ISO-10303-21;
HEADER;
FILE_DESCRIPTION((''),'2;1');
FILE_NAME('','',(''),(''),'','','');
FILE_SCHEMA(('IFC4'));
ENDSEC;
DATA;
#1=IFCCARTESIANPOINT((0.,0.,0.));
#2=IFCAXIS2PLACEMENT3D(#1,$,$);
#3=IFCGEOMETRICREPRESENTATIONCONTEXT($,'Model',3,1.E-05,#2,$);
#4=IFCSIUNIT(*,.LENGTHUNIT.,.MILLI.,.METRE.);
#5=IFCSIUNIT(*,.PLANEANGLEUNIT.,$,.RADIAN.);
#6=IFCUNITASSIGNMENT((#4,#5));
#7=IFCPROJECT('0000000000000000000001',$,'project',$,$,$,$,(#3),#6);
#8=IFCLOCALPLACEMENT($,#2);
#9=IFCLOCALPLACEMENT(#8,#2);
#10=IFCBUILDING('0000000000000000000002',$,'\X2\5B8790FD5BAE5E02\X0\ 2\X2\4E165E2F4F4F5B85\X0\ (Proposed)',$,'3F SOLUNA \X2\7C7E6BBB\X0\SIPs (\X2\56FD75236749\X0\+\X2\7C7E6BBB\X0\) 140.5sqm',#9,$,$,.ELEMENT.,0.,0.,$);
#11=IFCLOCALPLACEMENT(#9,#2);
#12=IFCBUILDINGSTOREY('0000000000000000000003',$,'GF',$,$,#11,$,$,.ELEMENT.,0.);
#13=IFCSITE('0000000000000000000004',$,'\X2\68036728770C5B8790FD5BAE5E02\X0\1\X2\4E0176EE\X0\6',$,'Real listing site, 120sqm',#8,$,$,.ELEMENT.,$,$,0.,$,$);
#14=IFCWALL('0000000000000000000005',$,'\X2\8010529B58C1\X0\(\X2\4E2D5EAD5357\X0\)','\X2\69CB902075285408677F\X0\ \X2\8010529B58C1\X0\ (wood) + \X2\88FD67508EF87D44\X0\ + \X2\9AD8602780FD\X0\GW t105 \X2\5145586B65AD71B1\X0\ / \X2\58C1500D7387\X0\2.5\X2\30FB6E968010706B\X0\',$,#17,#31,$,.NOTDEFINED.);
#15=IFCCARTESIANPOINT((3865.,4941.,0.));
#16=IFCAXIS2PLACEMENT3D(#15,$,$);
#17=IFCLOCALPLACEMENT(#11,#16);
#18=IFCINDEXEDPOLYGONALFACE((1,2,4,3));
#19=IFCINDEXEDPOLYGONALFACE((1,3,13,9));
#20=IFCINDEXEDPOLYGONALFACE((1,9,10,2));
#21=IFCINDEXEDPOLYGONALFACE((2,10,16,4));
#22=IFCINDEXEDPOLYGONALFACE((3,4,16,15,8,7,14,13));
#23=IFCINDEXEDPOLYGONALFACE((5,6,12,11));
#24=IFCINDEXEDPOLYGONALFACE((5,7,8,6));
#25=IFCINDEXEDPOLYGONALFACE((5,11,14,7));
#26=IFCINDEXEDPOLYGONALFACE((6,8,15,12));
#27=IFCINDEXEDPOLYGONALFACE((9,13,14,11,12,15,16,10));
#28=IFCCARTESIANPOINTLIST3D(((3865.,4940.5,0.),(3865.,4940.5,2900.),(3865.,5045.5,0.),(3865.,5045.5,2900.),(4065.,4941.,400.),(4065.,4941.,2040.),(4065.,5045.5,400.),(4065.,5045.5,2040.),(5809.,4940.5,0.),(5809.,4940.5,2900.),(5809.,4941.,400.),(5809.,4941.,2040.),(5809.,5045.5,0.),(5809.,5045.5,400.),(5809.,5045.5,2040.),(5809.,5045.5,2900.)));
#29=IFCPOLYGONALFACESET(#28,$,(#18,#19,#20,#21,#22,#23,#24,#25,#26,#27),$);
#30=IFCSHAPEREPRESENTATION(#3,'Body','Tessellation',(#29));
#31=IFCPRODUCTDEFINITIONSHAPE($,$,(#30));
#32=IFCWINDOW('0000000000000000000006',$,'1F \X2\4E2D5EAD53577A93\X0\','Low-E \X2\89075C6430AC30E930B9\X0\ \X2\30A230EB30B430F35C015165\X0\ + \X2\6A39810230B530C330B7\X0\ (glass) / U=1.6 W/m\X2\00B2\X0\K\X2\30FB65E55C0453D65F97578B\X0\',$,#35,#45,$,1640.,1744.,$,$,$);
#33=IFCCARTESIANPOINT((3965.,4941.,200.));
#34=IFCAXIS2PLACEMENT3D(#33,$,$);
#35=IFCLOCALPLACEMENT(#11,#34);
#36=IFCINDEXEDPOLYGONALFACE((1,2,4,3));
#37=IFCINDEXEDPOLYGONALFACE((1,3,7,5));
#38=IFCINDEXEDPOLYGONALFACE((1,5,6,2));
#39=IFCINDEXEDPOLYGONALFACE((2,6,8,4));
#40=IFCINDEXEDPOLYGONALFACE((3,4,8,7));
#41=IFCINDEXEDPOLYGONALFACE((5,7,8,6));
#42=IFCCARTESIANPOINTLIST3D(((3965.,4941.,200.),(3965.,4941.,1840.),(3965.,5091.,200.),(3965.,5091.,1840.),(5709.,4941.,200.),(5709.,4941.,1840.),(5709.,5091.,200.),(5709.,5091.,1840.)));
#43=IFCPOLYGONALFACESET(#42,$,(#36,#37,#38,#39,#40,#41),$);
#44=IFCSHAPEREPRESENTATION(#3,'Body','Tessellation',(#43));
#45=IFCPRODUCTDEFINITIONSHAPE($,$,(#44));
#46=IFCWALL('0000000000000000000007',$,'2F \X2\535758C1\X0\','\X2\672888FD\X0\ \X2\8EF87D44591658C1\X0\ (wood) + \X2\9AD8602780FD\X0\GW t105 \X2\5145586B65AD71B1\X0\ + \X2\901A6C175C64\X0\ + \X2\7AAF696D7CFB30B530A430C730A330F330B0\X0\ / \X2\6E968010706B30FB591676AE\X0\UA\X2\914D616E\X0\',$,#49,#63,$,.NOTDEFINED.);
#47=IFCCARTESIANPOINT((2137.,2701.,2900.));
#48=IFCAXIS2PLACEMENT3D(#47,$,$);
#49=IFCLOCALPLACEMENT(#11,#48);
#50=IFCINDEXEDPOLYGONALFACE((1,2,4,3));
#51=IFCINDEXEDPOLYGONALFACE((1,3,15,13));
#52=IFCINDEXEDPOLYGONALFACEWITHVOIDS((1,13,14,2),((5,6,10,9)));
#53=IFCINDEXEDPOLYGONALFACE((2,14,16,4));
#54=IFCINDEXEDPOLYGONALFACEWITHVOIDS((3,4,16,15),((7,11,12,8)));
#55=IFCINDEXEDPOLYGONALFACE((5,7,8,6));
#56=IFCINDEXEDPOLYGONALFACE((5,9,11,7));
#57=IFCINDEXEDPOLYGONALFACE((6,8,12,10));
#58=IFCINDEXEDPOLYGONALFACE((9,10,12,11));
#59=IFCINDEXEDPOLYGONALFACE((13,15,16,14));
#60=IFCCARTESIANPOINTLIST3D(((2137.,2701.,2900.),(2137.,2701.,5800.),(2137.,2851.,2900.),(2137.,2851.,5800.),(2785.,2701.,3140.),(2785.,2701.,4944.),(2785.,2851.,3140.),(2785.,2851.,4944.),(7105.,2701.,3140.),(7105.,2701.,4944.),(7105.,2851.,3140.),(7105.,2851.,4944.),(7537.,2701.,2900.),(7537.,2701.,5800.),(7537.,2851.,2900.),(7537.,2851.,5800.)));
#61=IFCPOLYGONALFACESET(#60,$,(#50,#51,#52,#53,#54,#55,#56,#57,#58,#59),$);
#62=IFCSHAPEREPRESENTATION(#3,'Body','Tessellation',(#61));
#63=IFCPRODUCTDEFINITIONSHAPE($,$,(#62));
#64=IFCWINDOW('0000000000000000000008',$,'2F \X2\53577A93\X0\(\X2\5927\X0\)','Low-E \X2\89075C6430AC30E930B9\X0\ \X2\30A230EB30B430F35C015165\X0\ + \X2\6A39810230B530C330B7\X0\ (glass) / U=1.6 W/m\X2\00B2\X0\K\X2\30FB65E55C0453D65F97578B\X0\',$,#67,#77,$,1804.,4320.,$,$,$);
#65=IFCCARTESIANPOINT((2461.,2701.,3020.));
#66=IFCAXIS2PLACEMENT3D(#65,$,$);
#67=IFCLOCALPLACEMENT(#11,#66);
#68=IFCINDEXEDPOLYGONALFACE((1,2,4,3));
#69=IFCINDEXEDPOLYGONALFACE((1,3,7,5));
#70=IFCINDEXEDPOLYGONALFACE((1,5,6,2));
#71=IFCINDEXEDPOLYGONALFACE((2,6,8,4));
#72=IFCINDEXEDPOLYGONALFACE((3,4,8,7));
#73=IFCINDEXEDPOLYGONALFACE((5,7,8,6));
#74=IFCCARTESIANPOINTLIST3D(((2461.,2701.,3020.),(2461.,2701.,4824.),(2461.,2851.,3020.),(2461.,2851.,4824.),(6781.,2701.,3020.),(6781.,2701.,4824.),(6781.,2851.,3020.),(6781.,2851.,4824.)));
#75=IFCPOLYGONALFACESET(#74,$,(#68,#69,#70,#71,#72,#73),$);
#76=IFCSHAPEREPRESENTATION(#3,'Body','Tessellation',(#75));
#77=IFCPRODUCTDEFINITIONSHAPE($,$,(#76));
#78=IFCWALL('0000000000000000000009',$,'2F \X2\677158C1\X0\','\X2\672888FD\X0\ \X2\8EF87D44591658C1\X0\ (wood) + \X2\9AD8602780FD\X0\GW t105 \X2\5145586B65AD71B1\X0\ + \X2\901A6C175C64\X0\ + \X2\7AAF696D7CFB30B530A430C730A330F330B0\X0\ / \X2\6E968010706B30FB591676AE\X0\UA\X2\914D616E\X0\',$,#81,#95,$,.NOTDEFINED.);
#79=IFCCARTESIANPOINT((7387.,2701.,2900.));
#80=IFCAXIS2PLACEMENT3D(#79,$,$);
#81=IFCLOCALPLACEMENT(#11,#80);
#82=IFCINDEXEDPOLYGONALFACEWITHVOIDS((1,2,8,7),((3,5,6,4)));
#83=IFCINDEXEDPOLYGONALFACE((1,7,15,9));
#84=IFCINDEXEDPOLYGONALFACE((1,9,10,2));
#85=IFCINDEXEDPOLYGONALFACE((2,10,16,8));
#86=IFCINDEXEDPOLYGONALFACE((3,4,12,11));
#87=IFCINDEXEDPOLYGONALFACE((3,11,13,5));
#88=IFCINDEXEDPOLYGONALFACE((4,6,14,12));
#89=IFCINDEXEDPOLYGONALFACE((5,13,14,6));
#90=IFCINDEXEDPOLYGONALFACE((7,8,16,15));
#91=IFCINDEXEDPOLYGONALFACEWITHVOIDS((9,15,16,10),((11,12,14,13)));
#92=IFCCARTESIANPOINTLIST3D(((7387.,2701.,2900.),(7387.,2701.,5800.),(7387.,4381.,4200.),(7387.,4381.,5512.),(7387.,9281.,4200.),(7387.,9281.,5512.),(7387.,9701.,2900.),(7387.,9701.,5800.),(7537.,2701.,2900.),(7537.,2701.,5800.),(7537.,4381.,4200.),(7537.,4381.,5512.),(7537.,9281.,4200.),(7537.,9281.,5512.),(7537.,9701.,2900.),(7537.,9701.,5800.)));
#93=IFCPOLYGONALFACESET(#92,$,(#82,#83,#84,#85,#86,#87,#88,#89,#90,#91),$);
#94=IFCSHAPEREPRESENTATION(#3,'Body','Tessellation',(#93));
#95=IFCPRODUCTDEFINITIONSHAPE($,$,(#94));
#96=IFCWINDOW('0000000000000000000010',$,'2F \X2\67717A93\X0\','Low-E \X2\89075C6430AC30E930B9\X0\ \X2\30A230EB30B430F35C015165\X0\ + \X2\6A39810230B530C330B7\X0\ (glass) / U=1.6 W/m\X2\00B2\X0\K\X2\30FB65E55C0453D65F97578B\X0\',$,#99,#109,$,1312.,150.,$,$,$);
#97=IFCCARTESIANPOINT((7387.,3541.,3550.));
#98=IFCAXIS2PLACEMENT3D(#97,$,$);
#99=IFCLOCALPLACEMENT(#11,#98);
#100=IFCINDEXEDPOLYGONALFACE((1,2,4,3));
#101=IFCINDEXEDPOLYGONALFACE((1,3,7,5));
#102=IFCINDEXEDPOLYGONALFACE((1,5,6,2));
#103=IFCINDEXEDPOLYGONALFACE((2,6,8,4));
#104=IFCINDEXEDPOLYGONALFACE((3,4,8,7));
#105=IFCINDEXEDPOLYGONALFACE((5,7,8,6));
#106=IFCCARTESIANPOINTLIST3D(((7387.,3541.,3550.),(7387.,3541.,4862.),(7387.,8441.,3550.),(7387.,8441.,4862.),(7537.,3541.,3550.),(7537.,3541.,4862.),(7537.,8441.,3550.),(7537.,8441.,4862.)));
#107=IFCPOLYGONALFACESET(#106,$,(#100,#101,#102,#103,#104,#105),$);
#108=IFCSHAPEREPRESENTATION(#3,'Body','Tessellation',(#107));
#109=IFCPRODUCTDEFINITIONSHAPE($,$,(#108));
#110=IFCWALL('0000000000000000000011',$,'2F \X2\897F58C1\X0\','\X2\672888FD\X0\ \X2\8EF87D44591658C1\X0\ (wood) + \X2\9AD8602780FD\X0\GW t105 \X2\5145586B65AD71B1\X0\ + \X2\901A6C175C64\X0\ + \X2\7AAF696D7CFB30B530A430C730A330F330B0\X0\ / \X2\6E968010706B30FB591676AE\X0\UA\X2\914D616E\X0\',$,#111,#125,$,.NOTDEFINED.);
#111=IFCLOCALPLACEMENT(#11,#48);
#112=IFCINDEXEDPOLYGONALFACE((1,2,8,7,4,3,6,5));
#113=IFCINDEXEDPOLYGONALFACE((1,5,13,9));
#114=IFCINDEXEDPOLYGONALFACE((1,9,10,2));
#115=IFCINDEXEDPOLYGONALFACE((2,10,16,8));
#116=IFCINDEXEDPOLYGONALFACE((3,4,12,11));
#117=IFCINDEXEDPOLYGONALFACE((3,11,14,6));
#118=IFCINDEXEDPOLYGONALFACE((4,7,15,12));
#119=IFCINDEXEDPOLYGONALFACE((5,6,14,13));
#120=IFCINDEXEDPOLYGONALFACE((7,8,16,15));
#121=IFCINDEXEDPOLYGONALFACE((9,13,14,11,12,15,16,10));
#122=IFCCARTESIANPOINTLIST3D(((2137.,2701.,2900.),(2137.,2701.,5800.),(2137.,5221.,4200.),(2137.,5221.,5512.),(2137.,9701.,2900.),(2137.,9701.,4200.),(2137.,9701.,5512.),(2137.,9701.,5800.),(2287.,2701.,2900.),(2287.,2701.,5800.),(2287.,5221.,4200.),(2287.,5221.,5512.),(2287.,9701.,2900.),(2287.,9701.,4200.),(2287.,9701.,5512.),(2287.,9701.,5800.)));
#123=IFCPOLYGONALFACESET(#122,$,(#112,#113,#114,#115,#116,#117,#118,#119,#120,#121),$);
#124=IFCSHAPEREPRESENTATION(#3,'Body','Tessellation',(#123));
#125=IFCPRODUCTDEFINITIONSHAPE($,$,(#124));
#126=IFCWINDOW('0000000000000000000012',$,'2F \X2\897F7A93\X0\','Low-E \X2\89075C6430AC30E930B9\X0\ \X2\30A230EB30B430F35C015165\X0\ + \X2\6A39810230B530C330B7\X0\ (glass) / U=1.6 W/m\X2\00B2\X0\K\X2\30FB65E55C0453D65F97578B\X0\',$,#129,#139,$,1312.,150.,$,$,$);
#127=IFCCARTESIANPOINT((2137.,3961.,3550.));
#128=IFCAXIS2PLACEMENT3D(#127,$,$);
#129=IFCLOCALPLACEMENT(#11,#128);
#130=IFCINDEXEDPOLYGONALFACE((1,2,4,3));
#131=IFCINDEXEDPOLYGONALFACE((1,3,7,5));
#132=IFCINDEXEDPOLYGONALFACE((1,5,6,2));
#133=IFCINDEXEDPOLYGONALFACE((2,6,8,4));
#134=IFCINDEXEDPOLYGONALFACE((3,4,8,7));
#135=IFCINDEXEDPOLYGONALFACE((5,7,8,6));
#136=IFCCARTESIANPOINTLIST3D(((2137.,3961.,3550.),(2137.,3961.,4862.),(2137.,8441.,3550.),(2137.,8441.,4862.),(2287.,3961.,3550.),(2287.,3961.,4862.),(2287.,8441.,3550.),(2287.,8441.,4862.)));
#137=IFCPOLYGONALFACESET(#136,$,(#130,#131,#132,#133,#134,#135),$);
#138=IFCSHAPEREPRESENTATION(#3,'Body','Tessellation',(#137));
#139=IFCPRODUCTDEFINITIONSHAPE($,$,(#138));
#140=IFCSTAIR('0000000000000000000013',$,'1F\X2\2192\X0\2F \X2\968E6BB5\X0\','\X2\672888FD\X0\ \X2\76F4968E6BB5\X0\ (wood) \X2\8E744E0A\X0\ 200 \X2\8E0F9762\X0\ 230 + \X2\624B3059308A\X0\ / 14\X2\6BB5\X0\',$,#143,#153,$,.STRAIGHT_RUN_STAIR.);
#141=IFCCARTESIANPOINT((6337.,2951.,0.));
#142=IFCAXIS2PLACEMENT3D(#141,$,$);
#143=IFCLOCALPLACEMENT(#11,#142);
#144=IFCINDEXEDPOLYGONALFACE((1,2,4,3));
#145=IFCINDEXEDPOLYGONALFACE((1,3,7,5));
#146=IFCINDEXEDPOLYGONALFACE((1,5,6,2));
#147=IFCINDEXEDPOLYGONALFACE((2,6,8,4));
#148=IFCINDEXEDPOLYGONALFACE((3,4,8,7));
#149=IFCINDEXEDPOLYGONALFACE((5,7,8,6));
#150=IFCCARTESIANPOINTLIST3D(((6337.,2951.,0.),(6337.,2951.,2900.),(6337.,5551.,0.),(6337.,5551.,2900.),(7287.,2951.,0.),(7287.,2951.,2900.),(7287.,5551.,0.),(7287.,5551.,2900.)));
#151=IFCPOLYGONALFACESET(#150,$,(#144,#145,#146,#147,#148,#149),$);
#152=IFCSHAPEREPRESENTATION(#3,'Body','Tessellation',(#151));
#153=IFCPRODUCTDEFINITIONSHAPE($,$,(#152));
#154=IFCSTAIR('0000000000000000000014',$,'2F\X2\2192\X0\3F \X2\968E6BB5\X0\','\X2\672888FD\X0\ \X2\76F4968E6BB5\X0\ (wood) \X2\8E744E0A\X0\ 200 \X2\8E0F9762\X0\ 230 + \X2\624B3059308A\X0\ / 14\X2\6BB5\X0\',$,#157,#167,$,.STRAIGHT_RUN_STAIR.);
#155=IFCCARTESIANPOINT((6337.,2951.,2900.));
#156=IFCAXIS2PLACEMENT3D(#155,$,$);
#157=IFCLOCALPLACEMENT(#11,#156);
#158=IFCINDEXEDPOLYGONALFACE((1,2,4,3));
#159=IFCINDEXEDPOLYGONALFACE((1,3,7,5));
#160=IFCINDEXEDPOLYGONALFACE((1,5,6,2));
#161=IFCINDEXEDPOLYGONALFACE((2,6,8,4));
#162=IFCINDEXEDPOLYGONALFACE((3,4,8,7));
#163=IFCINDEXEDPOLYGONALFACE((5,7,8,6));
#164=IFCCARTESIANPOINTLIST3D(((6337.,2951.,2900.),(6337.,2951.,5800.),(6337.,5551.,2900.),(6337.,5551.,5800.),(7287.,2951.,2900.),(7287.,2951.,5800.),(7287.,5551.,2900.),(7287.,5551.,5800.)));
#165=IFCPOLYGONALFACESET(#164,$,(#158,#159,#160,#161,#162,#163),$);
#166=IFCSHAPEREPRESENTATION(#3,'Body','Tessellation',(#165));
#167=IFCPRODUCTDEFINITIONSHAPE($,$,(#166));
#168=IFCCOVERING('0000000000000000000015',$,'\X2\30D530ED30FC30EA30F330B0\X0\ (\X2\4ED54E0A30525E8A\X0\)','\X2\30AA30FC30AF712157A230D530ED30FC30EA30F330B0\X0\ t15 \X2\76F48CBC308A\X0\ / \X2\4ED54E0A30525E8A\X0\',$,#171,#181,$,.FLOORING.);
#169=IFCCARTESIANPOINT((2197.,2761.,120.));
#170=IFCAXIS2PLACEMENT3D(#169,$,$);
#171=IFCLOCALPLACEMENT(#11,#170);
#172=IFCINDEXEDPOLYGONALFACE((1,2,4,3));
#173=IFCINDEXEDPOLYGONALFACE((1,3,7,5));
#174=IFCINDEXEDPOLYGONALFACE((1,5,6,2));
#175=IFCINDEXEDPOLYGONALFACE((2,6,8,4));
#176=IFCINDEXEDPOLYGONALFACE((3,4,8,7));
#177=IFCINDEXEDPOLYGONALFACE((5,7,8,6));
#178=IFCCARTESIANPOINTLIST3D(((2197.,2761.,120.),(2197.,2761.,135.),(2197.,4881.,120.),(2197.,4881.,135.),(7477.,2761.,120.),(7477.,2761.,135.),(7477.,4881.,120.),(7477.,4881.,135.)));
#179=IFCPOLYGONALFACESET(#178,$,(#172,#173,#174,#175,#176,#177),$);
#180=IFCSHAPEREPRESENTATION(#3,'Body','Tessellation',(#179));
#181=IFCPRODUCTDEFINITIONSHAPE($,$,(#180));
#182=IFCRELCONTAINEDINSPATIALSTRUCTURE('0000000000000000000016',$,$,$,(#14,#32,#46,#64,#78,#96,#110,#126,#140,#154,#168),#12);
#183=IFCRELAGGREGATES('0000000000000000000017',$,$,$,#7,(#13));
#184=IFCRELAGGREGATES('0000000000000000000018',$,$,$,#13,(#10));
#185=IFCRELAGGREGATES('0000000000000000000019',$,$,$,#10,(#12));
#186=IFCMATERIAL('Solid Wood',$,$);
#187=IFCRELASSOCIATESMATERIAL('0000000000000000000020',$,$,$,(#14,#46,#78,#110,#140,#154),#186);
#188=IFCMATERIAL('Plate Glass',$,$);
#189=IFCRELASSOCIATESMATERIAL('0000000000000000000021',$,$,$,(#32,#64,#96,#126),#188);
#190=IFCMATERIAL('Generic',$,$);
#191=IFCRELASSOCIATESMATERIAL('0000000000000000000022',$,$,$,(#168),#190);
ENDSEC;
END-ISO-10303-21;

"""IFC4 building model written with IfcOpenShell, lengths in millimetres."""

from ifc_helpers import new_model, si_unit, frame, frame_2d, origin, place, context, project, spatial, rectangle, extrude, material, element, fill, save


model = new_model("IFC4")

# Units and contexts
model_context = context("Model", 3, precision=1e-05, world=origin())
ifc_project = project(units=[si_unit("LENGTHUNIT", "METRE", prefix="MILLI"), si_unit("PLANEANGLEUNIT", "RADIAN")], contexts=[model_context])

# Site, building, storey
site_placement = place(None, origin())
site = spatial("IfcSite", under=ifc_project, at=site_placement, Name="栃木県宇都宮市1丁目6", ObjectType="Real listing site, 120sqm", CompositionType="ELEMENT", RefElevation=0.0)
building_placement = place(site_placement, origin())
building = spatial("IfcBuilding", under=site, at=building_placement, Name="宇都宮市 2世帯住宅 (Proposed)", ObjectType="3F SOLUNA 籾殻SIPs (国産杉+籾殻) 140.5sqm", CompositionType="ELEMENT", ElevationOfRefHeight=0.0, ElevationOfTerrain=0.0)
storey_placement = place(building_placement, origin())
storey = spatial("IfcBuildingStorey", under=building, at=storey_placement, Name="GF", CompositionType="ELEMENT", Elevation=0.0)

# Shared definitions
ifc_material_1 = material(Name="Solid Wood")

# Shared definitions
ifc_material_2 = material(Name="Plate Glass")

# Walls, openings, windows
wall_1_placement = place(storey_placement, frame((3865.0, 4941.0, 0.0)))
wall_1 = element("IfcWall", 1, at=wall_1_placement, inside=storey, material=ifc_material_1, Name="耐力壁(中庭南)", Description="構造用合板 耐力壁 (wood) + 製材軸組 + 高性能GW t105 充填断熱 / 壁倍率2.5・準耐火", PredefinedType="NOTDEFINED", context=model_context, shape_type="SweptSolid", body=[
    extrude(rectangle(XDim=1944.0, YDim=105.0, at=frame_2d((972.0, 52.0))), frame((3865.0, 4941.0, 0.0)), (0.0, 0.0, 1.0), 2900.0),
])
opening_1_placement = place(storey_placement, frame((3965.0, 4941.0, 200.0)))
opening_1 = element("IfcOpeningElement", 2, at=opening_1_placement, cuts=wall_1, PredefinedType="NOTDEFINED", context=model_context, shape_type="SweptSolid", body=[
    extrude(rectangle(XDim=1744.0, YDim=150.0, at=frame_2d((872.0, 75.0))), frame((3965.0, 4941.0, 200.0)), (0.0, 0.0, 1.0), 1640.0),
])
window_1_placement = place(storey_placement, frame((3965.0, 4941.0, 200.0)))
window_1 = element("IfcWindow", 3, at=window_1_placement, inside=storey, material=ifc_material_2, Name="1F 中庭南窓", Description="Low-E 複層ガラス アルゴン封入 + 樹脂サッシ (glass) / U=1.6 W/m²K・日射取得型", OverallHeight=1640.0, OverallWidth=1744.0, context=model_context, shape_type="SweptSolid", body=[
    extrude(rectangle(XDim=1744.0, YDim=150.0, at=frame_2d((872.0, 75.0))), frame((3965.0, 4941.0, 200.0)), (0.0, 0.0, 1.0), 1640.0),
])
fill(opening_1, window_1)
wall_2_placement = place(storey_placement, frame((2137.0, 2701.0, 2900.0)))
wall_2 = element("IfcWall", 4, at=wall_2_placement, inside=storey, material=ifc_material_1, Name="2F 南壁", Description="木製 軸組外壁 (wood) + 高性能GW t105 充填断熱 + 通気層 + 窯業系サイディング / 準耐火・外皮UA配慮", PredefinedType="NOTDEFINED", context=model_context, shape_type="SweptSolid", body=[
    extrude(rectangle(XDim=5400.0, YDim=150.0, at=frame_2d((2700.0, 75.0))), frame((2137.0, 2701.0, 2900.0)), (0.0, 0.0, 1.0), 2900.0),
])
opening_2_placement = place(storey_placement, frame((2461.0, 2701.0, 3020.0)))
opening_2 = element("IfcOpeningElement", 5, at=opening_2_placement, cuts=wall_2, PredefinedType="NOTDEFINED", context=model_context, shape_type="SweptSolid", body=[
    extrude(rectangle(XDim=4320.0, YDim=150.0, at=frame_2d((2160.0, 75.0))), frame((2461.0, 2701.0, 3020.0)), (0.0, 0.0, 1.0), 1804.0),
])
window_2_placement = place(storey_placement, frame((2461.0, 2701.0, 3020.0)))
window_2 = element("IfcWindow", 6, at=window_2_placement, inside=storey, material=ifc_material_2, Name="2F 南窓(大)", Description="Low-E 複層ガラス アルゴン封入 + 樹脂サッシ (glass) / U=1.6 W/m²K・日射取得型", OverallHeight=1804.0, OverallWidth=4320.0, context=model_context, shape_type="SweptSolid", body=[
    extrude(rectangle(XDim=4320.0, YDim=150.0, at=frame_2d((2160.0, 75.0))), frame((2461.0, 2701.0, 3020.0)), (0.0, 0.0, 1.0), 1804.0),
])
fill(opening_2, window_2)
wall_3_placement = place(storey_placement, frame((7387.0, 2701.0, 2900.0)))
wall_3 = element("IfcWall", 7, at=wall_3_placement, inside=storey, material=ifc_material_1, Name="2F 東壁", Description="木製 軸組外壁 (wood) + 高性能GW t105 充填断熱 + 通気層 + 窯業系サイディング / 準耐火・外皮UA配慮", PredefinedType="NOTDEFINED", context=model_context, shape_type="SweptSolid", body=[
    extrude(rectangle(XDim=150.0, YDim=7000.0, at=frame_2d((75.0, 3500.0))), frame((7387.0, 2701.0, 2900.0)), (0.0, 0.0, 1.0), 2900.0),
])
opening_3_placement = place(storey_placement, frame((7387.0, 3541.0, 3550.0)))
opening_3 = element("IfcOpeningElement", 8, at=opening_3_placement, cuts=wall_3, PredefinedType="NOTDEFINED", context=model_context, shape_type="SweptSolid", body=[
    extrude(rectangle(XDim=150.0, YDim=4900.0, at=frame_2d((75.0, 2450.0))), frame((7387.0, 3541.0, 3550.0)), (0.0, 0.0, 1.0), 1312.0),
])
window_3_placement = place(storey_placement, frame((7387.0, 3541.0, 3550.0)))
window_3 = element("IfcWindow", 9, at=window_3_placement, inside=storey, material=ifc_material_2, Name="2F 東窓", Description="Low-E 複層ガラス アルゴン封入 + 樹脂サッシ (glass) / U=1.6 W/m²K・日射取得型", OverallHeight=1312.0, OverallWidth=150.0, context=model_context, shape_type="SweptSolid", body=[
    extrude(rectangle(XDim=150.0, YDim=4900.0, at=frame_2d((75.0, 2450.0))), frame((7387.0, 3541.0, 3550.0)), (0.0, 0.0, 1.0), 1312.0),
])
fill(opening_3, window_3)
wall_4_placement = place(storey_placement, frame((2137.0, 2701.0, 2900.0)))
wall_4 = element("IfcWall", 10, at=wall_4_placement, inside=storey, material=ifc_material_1, Name="2F 西壁", Description="木製 軸組外壁 (wood) + 高性能GW t105 充填断熱 + 通気層 + 窯業系サイディング / 準耐火・外皮UA配慮", PredefinedType="NOTDEFINED", context=model_context, shape_type="SweptSolid", body=[
    extrude(rectangle(XDim=150.0, YDim=7000.0, at=frame_2d((75.0, 3500.0))), frame((2137.0, 2701.0, 2900.0)), (0.0, 0.0, 1.0), 2900.0),
])
opening_4_placement = place(storey_placement, frame((2137.0, 3961.0, 3550.0)))
opening_4 = element("IfcOpeningElement", 11, at=opening_4_placement, cuts=wall_4, PredefinedType="NOTDEFINED", context=model_context, shape_type="SweptSolid", body=[
    extrude(rectangle(XDim=150.0, YDim=4480.0, at=frame_2d((75.0, 2240.0))), frame((2137.0, 3961.0, 3550.0)), (0.0, 0.0, 1.0), 1312.0),
])
window_4_placement = place(storey_placement, frame((2137.0, 3961.0, 3550.0)))
window_4 = element("IfcWindow", 12, at=window_4_placement, inside=storey, material=ifc_material_2, Name="2F 西窓", Description="Low-E 複層ガラス アルゴン封入 + 樹脂サッシ (glass) / U=1.6 W/m²K・日射取得型", OverallHeight=1312.0, OverallWidth=150.0, context=model_context, shape_type="SweptSolid", body=[
    extrude(rectangle(XDim=150.0, YDim=4480.0, at=frame_2d((75.0, 2240.0))), frame((2137.0, 3961.0, 3550.0)), (0.0, 0.0, 1.0), 1312.0),
])
fill(opening_4, window_4)

# Stairs
stair_1_placement = place(storey_placement, frame((6337.0, 2951.0, 0.0)))
element("IfcStair", 13, at=stair_1_placement, inside=storey, material=ifc_material_1, Name="1F→2F 階段", Description="木製 直階段 (wood) 蹴上 200 踏面 230 + 手すり / 14段", PredefinedType="STRAIGHT_RUN_STAIR", context=model_context, shape_type="SweptSolid", body=[
    extrude(rectangle(XDim=950.0, YDim=2600.0, at=frame_2d((475.0, 1300.0))), frame((6337.0, 2951.0, 0.0)), (0.0, 0.0, 1.0), 2900.0),
])
stair_2_placement = place(storey_placement, frame((6337.0, 2951.0, 2900.0)))
element("IfcStair", 14, at=stair_2_placement, inside=storey, material=ifc_material_1, Name="2F→3F 階段", Description="木製 直階段 (wood) 蹴上 200 踏面 230 + 手すり / 14段", PredefinedType="STRAIGHT_RUN_STAIR", context=model_context, shape_type="SweptSolid", body=[
    extrude(rectangle(XDim=950.0, YDim=2600.0, at=frame_2d((475.0, 1300.0))), frame((6337.0, 2951.0, 2900.0)), (0.0, 0.0, 1.0), 2900.0),
])

# Covering
ifc_material_3 = material(Name="Generic")
covering_placement = place(storey_placement, frame((2197.0, 2761.0, 120.0)))
element("IfcCovering", 15, at=covering_placement, inside=storey, material=ifc_material_3, Name="フローリング (仕上げ床)", Description="オーク無垢フローリング t15 直貼り / 仕上げ床", PredefinedType="FLOORING", context=model_context, shape_type="SweptSolid", body=[
    extrude(rectangle(XDim=5280.0, YDim=2120.0, at=frame_2d((2640.0, 1060.0))), frame((2197.0, 2761.0, 120.0)), (0.0, 0.0, 1.0), 15.0),
])

save(model, "model.ifc")
